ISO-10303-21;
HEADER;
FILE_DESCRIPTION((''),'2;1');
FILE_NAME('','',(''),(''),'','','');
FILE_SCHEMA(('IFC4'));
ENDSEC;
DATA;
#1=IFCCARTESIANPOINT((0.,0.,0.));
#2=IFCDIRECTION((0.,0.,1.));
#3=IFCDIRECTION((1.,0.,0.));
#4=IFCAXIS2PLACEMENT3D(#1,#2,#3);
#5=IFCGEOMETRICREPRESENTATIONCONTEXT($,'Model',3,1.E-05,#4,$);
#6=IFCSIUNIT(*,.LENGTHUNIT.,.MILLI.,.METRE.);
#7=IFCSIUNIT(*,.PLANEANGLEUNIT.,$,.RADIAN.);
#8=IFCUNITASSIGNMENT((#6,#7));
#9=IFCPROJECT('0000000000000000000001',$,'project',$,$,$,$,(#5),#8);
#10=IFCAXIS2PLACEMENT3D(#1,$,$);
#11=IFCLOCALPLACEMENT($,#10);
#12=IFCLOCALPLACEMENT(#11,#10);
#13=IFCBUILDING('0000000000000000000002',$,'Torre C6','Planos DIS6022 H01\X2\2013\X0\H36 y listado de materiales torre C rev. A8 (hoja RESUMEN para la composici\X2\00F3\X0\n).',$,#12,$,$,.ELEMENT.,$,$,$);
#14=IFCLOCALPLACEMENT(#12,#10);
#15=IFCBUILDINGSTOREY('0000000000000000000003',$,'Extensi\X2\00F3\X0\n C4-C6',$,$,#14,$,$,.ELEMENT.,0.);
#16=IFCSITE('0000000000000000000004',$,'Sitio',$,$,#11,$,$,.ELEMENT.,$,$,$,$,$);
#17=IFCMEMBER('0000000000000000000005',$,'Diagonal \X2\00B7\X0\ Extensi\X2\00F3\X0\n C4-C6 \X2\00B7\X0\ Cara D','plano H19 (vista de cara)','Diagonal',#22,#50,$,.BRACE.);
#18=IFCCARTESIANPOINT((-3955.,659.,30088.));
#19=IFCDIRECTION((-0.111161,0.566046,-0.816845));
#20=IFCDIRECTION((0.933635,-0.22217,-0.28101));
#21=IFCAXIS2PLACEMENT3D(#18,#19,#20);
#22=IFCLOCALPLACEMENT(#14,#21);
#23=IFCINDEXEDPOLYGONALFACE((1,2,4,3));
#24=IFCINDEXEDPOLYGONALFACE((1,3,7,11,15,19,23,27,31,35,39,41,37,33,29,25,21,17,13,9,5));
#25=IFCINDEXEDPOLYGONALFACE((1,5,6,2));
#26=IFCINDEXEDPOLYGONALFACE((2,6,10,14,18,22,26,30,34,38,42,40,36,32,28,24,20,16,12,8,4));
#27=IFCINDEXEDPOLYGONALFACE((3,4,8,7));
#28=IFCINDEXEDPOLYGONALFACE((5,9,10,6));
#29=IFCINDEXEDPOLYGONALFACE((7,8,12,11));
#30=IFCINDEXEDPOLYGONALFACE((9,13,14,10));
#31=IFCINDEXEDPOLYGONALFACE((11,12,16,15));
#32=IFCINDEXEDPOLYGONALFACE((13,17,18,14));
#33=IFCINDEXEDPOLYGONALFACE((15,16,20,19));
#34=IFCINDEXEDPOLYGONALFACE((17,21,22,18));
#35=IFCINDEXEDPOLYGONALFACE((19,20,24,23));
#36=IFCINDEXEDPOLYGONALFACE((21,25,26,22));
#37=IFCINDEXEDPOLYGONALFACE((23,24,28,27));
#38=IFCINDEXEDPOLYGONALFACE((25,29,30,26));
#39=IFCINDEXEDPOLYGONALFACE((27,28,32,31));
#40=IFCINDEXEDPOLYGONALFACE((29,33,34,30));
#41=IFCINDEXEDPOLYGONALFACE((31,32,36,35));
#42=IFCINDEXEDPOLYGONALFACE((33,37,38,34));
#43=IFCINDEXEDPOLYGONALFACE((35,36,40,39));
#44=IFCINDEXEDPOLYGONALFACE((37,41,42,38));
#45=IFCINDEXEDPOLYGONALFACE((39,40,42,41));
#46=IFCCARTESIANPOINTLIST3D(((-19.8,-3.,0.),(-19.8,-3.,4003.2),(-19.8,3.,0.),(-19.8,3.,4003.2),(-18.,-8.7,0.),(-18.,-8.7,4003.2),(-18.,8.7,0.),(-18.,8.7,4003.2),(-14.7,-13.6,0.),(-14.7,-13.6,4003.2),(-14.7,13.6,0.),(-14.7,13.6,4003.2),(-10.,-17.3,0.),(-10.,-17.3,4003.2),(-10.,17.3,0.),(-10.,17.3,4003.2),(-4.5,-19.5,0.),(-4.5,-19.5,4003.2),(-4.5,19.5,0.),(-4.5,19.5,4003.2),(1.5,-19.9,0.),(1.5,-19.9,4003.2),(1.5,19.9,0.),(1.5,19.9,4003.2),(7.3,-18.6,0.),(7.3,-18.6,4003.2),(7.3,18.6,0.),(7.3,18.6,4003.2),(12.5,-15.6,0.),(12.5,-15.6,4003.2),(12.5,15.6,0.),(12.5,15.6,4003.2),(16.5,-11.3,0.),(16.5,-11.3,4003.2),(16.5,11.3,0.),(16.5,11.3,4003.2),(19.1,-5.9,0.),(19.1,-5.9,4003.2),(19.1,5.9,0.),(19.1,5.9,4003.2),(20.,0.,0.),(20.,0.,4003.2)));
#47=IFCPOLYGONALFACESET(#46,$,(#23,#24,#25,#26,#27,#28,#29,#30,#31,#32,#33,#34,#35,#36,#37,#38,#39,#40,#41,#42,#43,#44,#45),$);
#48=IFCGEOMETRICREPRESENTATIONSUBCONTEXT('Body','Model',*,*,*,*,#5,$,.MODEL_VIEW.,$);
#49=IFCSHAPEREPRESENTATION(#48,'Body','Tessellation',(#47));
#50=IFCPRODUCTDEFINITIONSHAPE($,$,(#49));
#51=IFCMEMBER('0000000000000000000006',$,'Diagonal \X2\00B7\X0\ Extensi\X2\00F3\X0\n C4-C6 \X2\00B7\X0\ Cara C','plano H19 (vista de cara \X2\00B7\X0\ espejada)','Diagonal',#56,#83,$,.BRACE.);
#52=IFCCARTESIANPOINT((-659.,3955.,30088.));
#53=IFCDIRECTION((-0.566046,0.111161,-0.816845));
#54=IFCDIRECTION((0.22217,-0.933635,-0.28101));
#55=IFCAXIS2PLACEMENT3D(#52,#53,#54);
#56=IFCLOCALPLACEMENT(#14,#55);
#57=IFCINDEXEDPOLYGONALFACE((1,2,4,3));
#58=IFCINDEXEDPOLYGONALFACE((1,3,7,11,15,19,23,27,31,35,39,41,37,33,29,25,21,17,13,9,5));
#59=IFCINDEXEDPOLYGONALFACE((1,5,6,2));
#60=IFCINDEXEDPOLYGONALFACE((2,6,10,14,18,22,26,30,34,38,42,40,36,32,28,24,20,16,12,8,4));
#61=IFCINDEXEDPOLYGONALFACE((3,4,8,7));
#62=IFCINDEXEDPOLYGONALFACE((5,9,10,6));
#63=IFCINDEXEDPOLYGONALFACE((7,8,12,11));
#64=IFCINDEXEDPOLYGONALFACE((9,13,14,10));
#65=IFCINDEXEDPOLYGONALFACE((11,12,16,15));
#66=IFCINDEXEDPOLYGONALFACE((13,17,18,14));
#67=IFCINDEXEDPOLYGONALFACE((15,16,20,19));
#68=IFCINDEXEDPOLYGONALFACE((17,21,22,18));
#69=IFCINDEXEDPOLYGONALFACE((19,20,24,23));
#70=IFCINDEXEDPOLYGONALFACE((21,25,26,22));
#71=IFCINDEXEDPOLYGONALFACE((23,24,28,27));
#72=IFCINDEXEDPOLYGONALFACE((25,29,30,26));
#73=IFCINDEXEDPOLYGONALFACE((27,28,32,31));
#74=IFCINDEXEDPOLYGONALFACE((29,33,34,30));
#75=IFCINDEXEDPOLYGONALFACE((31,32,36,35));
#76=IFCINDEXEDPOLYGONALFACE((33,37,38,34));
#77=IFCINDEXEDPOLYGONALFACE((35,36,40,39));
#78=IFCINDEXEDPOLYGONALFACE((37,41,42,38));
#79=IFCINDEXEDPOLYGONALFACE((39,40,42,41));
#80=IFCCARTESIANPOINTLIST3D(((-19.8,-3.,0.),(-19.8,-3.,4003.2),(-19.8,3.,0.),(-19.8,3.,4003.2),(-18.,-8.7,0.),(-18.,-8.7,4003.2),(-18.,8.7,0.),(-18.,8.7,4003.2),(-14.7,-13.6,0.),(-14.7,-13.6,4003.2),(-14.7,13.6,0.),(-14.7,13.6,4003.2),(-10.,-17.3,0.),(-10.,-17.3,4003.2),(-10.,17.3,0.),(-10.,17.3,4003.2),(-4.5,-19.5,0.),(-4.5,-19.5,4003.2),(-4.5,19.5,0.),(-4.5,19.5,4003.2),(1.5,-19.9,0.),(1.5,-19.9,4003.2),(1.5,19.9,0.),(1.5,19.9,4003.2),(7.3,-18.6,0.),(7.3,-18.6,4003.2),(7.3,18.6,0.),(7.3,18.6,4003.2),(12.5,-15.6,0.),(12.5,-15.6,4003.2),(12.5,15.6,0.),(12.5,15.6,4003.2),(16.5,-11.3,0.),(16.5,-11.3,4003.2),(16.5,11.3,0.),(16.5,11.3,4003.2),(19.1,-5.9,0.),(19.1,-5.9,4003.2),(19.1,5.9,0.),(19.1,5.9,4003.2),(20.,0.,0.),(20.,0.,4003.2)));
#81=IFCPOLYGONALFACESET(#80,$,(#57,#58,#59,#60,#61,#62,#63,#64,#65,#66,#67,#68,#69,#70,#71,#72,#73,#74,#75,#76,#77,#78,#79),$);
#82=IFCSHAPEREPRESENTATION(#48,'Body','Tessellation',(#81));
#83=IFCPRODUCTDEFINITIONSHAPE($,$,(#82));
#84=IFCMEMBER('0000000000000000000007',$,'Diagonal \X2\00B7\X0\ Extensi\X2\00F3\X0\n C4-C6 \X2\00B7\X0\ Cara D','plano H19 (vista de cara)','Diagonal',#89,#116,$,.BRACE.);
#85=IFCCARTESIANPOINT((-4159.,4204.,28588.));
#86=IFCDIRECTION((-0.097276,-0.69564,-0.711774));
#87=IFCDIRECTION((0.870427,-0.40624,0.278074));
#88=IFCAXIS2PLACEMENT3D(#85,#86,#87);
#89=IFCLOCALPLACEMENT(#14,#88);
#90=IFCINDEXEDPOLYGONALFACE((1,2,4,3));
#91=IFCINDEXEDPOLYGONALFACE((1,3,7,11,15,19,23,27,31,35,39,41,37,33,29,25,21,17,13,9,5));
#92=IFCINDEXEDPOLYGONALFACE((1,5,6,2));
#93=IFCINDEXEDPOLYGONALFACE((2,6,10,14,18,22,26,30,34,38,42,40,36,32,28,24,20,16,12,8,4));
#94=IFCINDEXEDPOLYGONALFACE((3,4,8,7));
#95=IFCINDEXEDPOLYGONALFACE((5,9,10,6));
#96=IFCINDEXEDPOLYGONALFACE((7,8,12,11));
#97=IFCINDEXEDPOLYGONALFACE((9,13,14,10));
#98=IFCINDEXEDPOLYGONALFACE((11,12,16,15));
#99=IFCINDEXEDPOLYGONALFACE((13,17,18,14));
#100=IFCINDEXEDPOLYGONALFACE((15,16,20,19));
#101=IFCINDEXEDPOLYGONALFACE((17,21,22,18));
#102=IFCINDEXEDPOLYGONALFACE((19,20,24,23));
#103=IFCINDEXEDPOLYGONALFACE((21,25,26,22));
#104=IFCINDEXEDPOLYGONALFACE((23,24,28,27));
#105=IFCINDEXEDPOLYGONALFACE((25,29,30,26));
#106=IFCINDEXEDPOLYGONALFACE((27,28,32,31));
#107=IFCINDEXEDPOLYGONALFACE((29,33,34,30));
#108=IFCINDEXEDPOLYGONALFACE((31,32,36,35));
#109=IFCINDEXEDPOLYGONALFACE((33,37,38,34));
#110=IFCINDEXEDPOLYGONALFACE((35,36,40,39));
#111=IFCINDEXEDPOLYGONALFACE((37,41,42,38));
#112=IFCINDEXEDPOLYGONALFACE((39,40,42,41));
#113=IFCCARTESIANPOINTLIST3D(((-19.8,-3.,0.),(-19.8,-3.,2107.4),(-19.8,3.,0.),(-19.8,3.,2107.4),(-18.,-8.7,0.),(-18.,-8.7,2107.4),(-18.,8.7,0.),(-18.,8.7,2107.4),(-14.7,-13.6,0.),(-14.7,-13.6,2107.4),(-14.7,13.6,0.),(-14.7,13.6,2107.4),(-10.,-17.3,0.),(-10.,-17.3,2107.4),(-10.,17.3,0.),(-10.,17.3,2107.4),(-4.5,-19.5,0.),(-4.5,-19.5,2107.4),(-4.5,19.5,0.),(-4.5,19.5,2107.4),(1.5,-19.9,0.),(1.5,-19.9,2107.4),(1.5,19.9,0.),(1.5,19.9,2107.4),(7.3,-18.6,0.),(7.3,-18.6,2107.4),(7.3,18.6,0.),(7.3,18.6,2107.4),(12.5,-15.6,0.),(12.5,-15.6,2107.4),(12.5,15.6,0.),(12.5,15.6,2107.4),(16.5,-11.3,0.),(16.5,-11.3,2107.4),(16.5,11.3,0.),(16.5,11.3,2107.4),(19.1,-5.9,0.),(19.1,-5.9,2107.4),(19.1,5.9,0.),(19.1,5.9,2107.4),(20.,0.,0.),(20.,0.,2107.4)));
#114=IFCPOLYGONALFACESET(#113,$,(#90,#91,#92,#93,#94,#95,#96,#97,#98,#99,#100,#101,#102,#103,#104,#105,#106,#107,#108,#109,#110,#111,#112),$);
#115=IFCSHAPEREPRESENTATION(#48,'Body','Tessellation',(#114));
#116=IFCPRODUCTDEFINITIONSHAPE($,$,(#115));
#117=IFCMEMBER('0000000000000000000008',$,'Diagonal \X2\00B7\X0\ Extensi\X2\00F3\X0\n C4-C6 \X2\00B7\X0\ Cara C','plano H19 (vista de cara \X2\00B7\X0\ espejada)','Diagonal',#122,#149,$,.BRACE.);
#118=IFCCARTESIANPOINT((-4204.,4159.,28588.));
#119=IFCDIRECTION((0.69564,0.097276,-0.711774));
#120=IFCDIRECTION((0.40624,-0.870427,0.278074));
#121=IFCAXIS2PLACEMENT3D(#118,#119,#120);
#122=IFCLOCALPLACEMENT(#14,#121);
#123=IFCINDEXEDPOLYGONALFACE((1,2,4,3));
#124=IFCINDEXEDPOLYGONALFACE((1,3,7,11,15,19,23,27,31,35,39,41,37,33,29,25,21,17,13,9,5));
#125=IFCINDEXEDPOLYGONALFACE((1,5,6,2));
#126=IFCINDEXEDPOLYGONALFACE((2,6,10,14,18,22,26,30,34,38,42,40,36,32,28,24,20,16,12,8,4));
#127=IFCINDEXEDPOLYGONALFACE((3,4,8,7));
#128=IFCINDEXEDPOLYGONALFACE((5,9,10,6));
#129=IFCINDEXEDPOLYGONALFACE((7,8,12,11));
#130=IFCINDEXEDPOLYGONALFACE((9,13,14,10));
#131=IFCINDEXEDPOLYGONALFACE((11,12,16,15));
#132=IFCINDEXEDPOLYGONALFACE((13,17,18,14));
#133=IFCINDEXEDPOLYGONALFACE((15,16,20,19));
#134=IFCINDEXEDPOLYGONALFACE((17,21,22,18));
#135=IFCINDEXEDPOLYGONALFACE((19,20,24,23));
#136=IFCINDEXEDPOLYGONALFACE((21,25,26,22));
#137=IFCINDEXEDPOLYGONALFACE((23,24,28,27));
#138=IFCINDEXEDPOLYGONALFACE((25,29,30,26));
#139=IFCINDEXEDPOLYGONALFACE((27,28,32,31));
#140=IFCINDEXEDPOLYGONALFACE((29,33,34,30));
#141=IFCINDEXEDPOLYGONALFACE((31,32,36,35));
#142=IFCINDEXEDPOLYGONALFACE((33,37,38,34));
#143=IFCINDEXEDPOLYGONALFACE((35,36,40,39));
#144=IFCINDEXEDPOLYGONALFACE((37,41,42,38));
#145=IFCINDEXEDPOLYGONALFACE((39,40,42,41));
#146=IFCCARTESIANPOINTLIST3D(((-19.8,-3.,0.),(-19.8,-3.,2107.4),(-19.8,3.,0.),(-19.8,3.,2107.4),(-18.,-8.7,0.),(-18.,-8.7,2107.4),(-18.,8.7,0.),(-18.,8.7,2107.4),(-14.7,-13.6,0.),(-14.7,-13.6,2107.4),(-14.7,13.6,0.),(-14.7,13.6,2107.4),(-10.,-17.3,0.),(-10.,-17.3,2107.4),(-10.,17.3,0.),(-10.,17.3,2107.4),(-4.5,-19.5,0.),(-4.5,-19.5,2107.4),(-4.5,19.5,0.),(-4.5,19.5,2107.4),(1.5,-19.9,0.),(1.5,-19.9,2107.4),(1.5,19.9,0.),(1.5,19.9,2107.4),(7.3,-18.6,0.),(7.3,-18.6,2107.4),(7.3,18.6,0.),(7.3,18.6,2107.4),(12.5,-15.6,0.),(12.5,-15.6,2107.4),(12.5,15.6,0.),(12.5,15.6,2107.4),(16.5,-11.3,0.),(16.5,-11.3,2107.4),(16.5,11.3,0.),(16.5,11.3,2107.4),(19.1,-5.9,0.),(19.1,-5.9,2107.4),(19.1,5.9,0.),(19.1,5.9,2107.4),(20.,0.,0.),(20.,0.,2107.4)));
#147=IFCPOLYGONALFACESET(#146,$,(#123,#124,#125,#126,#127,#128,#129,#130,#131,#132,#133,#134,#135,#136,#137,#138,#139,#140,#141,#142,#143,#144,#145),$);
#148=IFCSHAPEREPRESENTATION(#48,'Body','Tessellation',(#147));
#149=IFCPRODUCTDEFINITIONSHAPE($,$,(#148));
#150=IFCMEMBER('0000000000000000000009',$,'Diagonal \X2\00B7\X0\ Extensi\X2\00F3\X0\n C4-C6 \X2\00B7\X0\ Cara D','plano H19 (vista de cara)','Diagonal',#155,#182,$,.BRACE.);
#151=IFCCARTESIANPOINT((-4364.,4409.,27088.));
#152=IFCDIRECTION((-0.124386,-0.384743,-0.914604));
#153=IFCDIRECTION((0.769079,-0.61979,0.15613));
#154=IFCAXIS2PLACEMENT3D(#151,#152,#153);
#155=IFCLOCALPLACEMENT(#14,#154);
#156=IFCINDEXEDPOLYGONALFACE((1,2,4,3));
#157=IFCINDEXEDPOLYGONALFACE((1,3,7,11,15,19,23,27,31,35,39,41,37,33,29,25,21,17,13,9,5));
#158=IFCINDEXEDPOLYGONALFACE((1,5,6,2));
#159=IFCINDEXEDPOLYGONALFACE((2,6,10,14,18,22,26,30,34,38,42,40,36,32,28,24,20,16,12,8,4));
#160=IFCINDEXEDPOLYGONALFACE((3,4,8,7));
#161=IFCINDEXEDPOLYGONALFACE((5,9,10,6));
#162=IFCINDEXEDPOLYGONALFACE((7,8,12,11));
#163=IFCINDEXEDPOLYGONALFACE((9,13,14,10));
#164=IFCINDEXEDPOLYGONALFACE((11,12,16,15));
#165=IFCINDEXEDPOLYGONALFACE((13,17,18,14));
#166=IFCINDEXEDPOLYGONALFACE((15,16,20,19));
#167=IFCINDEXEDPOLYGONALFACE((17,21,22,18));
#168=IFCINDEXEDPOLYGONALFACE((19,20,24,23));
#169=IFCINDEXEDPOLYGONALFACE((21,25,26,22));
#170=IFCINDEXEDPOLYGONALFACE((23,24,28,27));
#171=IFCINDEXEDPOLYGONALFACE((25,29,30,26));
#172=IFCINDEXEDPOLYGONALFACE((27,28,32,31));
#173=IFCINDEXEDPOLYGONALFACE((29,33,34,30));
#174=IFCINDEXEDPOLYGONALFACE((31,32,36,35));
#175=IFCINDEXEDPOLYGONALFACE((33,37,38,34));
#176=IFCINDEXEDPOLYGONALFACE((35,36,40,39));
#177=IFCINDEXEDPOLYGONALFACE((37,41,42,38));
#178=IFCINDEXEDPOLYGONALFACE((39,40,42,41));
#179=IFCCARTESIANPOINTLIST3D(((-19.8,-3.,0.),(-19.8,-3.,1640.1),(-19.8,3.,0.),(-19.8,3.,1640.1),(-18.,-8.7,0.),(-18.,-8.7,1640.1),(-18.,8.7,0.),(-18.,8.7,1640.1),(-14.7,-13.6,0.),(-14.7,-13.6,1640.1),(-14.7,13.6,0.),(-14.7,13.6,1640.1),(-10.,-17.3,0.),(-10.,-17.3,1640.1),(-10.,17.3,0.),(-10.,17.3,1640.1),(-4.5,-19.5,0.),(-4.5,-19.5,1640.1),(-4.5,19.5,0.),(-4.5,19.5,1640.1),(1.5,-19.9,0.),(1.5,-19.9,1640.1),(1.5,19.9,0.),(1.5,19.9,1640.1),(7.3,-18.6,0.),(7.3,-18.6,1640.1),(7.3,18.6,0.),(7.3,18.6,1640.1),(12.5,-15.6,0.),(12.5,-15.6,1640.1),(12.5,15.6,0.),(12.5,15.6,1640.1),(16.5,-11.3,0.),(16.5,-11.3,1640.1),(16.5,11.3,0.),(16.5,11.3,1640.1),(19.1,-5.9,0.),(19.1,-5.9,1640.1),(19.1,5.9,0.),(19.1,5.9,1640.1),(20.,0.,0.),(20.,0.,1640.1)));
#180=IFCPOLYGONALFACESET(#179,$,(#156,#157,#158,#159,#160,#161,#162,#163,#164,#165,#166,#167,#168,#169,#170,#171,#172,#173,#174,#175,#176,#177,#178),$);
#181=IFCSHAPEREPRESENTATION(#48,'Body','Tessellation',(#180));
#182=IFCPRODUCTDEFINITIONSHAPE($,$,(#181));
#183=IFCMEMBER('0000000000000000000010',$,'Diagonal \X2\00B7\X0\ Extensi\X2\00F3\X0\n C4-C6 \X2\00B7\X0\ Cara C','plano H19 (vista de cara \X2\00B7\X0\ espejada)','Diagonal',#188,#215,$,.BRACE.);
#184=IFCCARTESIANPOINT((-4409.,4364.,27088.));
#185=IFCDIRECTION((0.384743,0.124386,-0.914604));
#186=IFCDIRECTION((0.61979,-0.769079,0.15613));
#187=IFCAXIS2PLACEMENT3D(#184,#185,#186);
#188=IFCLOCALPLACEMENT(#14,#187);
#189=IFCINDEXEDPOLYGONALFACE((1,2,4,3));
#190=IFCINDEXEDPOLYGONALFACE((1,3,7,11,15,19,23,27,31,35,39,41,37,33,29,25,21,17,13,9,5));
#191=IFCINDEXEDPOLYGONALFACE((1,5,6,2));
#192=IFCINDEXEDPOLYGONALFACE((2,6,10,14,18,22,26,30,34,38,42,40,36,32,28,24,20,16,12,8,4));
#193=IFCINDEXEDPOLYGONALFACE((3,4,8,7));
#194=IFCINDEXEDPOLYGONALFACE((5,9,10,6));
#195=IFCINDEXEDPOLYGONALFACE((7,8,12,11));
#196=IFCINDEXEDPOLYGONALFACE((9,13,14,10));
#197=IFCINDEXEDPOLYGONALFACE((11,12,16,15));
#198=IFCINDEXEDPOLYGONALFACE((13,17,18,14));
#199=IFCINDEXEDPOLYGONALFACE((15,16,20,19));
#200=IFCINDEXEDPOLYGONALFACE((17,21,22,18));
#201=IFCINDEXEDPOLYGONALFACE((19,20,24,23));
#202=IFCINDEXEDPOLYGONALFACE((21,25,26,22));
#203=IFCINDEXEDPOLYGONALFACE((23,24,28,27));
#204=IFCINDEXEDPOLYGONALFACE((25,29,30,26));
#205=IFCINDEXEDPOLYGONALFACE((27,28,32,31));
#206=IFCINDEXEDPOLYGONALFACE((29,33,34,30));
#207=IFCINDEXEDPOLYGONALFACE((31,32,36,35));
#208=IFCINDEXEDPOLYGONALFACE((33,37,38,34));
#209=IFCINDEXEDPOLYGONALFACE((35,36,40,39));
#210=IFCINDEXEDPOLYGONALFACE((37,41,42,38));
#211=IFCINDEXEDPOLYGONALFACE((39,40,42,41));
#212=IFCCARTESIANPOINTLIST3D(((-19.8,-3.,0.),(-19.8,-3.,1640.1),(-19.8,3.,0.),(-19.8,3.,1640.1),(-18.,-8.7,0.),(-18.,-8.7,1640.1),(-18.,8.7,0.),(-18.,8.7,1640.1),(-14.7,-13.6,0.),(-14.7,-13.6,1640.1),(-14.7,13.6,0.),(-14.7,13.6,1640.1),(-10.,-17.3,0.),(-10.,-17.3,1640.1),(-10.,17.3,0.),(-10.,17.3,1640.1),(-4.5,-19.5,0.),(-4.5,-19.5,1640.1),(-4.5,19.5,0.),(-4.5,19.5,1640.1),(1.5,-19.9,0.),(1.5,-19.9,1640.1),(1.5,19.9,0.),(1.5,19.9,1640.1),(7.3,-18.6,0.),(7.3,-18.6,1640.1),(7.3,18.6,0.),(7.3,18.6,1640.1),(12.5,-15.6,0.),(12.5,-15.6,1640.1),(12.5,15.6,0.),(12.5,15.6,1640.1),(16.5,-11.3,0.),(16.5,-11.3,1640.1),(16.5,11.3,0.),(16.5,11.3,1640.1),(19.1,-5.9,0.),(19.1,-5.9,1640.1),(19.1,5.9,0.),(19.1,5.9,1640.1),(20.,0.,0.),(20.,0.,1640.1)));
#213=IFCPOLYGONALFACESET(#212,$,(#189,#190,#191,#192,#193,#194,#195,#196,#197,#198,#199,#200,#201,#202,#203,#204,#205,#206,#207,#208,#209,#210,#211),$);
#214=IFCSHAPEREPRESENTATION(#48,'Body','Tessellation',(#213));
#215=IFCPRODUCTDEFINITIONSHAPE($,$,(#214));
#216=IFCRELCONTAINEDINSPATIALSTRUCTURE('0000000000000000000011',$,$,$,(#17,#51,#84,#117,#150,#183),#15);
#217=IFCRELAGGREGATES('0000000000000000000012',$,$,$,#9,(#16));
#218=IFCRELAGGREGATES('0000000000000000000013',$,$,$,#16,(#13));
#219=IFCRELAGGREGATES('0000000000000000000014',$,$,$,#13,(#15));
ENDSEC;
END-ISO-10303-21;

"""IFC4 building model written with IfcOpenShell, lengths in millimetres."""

from ifc_helpers import new_model, si_unit, frame, origin, origin_with_axes, place, context, subcontext, project, spatial, circle, extrude, element, save


model = new_model("IFC4")

# Units and contexts
model_context = context("Model", 3, precision=1e-05, world=origin_with_axes())
body_context = subcontext(model_context, "Body", "Model", "MODEL_VIEW")
ifc_project = project(units=[si_unit("LENGTHUNIT", "METRE", prefix="MILLI"), si_unit("PLANEANGLEUNIT", "RADIAN")], contexts=[model_context])

# Site, building, storey
site_placement = place(None, origin())
site = spatial("IfcSite", under=ifc_project, at=site_placement, Name="Sitio", CompositionType="ELEMENT")
building_placement = place(site_placement, origin())
building = spatial("IfcBuilding", under=site, at=building_placement, Name="Torre C6", Description="Planos DIS6022 H01–H36 y listado de materiales torre C rev. A8 (hoja RESUMEN para la composición).", CompositionType="ELEMENT")
storey_placement = place(building_placement, origin())
storey = spatial("IfcBuildingStorey", under=building, at=storey_placement, Name="Extensión C4-C6", CompositionType="ELEMENT", Elevation=0.0)

# Members
for number, where, z_axis, x_axis, name, description in (
    (1, (-3955.0, 659.0, 30088.0), (-0.111161, 0.566046, -0.816845), (0.933635, -0.22217, -0.28101), "Diagonal · Extensión C4-C6 · Cara D", "plano H19 (vista de cara)"),
    (2, (-659.0, 3955.0, 30088.0), (-0.566046, 0.111161, -0.816845), (0.22217, -0.933635, -0.28101), "Diagonal · Extensión C4-C6 · Cara C", "plano H19 (vista de cara · espejada)"),
):
    element("IfcMember", number, at=place(storey_placement, frame(where, z_axis=z_axis, x_axis=x_axis)), inside=storey, Name=name, Description=description, ObjectType="Diagonal", PredefinedType="BRACE", context=body_context, shape_type="SweptSolid", body=[
        extrude(circle(Radius=20.0), None, (0.0, 0.0, 1.0), 4003.2),
    ])
for number, where, z_axis, x_axis, name, description in (
    (3, (-4159.0, 4204.0, 28588.0), (-0.097276, -0.69564, -0.711774), (0.870427, -0.40624, 0.278074), "Diagonal · Extensión C4-C6 · Cara D", "plano H19 (vista de cara)"),
    (4, (-4204.0, 4159.0, 28588.0), (0.69564, 0.097276, -0.711774), (0.40624, -0.870427, 0.278074), "Diagonal · Extensión C4-C6 · Cara C", "plano H19 (vista de cara · espejada)"),
):
    element("IfcMember", number, at=place(storey_placement, frame(where, z_axis=z_axis, x_axis=x_axis)), inside=storey, Name=name, Description=description, ObjectType="Diagonal", PredefinedType="BRACE", context=body_context, shape_type="SweptSolid", body=[
        extrude(circle(Radius=20.0), None, (0.0, 0.0, 1.0), 2107.4),
    ])
for number, where, z_axis, x_axis, name, description in (
    (5, (-4364.0, 4409.0, 27088.0), (-0.124386, -0.384743, -0.914604), (0.769079, -0.61979, 0.15613), "Diagonal · Extensión C4-C6 · Cara D", "plano H19 (vista de cara)"),
    (6, (-4409.0, 4364.0, 27088.0), (0.384743, 0.124386, -0.914604), (0.61979, -0.769079, 0.15613), "Diagonal · Extensión C4-C6 · Cara C", "plano H19 (vista de cara · espejada)"),
):
    element("IfcMember", number, at=place(storey_placement, frame(where, z_axis=z_axis, x_axis=x_axis)), inside=storey, Name=name, Description=description, ObjectType="Diagonal", PredefinedType="BRACE", context=body_context, shape_type="SweptSolid", body=[
        extrude(circle(Radius=20.0), None, (0.0, 0.0, 1.0), 1640.1),
    ])

save(model, "model.ifc")
